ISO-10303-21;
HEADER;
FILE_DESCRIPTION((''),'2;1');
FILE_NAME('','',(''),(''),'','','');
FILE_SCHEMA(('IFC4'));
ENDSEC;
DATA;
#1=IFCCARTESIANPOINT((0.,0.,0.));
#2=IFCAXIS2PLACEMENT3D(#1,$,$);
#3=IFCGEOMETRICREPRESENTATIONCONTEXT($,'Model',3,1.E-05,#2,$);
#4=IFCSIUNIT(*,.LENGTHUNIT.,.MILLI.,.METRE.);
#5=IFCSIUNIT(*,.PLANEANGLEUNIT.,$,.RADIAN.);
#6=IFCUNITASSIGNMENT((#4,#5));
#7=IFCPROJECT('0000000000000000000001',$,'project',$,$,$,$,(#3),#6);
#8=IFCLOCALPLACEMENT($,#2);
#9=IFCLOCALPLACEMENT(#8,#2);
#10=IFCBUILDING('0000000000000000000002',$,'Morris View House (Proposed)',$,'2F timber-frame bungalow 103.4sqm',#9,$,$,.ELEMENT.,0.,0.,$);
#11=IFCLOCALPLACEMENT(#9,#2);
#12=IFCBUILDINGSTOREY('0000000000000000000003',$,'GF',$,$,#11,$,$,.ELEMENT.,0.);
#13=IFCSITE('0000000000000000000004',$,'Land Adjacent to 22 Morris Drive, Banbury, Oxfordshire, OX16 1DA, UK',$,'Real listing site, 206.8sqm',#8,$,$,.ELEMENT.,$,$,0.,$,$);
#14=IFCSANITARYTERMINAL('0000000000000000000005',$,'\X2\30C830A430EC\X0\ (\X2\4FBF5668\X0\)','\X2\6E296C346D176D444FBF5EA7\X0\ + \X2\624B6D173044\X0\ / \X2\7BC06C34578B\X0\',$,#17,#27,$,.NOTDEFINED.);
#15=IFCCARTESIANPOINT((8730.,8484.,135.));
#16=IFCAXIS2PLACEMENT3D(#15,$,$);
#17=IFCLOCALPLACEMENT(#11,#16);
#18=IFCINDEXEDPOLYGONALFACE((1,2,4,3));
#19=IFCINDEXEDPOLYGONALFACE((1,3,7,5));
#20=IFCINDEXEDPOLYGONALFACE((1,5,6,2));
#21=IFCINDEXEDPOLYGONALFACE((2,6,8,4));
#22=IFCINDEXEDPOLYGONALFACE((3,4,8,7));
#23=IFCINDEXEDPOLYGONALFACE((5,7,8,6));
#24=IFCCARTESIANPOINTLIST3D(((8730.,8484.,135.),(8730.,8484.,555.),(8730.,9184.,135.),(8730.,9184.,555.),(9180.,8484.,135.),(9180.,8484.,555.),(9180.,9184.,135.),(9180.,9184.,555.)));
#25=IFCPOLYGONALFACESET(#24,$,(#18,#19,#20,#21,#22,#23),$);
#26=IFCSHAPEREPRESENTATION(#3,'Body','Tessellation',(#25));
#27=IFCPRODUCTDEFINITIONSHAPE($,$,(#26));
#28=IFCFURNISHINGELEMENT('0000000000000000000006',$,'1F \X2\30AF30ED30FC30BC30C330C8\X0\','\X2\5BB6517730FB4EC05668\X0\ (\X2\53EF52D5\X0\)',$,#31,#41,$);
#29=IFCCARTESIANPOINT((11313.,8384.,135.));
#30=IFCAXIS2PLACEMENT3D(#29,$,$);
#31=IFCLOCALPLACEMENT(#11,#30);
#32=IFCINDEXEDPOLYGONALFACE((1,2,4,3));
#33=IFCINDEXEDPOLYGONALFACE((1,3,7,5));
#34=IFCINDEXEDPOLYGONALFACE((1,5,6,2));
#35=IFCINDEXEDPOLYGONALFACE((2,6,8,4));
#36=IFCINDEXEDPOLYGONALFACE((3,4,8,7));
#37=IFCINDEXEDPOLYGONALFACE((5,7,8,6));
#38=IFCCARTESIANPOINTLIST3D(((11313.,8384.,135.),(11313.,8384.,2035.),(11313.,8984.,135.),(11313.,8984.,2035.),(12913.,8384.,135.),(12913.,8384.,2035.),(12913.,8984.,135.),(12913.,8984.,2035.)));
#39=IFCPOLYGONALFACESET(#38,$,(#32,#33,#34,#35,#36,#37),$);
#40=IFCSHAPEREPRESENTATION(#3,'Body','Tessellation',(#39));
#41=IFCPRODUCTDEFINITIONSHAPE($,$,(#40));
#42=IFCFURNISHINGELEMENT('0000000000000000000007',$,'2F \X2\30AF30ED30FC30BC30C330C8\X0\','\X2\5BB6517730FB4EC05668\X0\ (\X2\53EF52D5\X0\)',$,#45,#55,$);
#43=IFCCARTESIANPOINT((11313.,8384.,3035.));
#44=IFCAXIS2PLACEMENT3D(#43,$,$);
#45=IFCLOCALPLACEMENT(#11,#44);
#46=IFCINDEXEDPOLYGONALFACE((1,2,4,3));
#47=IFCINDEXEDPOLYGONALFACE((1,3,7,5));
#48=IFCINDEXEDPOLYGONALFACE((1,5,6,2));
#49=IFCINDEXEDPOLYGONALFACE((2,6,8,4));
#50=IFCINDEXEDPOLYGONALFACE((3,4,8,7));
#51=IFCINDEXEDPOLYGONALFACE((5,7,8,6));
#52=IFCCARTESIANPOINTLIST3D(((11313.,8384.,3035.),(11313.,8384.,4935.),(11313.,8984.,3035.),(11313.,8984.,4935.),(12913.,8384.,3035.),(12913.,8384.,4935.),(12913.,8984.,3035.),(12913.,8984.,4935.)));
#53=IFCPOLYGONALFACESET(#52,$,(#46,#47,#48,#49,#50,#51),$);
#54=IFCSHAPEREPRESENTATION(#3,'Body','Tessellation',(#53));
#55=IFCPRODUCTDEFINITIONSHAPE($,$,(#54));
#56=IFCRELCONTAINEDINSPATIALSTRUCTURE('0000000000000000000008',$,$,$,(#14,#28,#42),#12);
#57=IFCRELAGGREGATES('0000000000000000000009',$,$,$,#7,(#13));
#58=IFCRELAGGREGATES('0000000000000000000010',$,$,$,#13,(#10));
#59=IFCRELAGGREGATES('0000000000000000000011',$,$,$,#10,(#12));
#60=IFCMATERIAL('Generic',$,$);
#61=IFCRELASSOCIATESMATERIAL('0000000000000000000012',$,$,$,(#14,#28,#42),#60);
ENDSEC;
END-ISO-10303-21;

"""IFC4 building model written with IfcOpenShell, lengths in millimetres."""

from ifc_helpers import new_model, si_unit, frame, frame_2d, origin, place, context, project, spatial, rectangle, extrude, material, element, save


model = new_model("IFC4")

# Units and contexts
model_context = context("Model", 3, precision=1e-05, world=origin())
ifc_project = project(units=[si_unit("LENGTHUNIT", "METRE", prefix="MILLI"), si_unit("PLANEANGLEUNIT", "RADIAN")], contexts=[model_context])

# Site, building, storey
site_placement = place(None, origin())
site = spatial("IfcSite", under=ifc_project, at=site_placement, Name="Land Adjacent to 22 Morris Drive, Banbury, Oxfordshire, OX16 1DA, UK", ObjectType="Real listing site, 206.8sqm", CompositionType="ELEMENT", RefElevation=0.0)
building_placement = place(site_placement, origin())
building = spatial("IfcBuilding", under=site, at=building_placement, Name="Morris View House (Proposed)", ObjectType="2F timber-frame bungalow 103.4sqm", CompositionType="ELEMENT", ElevationOfRefHeight=0.0, ElevationOfTerrain=0.0)
storey_placement = place(building_placement, origin())
storey = spatial("IfcBuildingStorey", under=building, at=storey_placement, Name="GF", CompositionType="ELEMENT", Elevation=0.0)

# Shared definitions
ifc_material_1 = material(Name="Generic")

# Sanitary terminal
sanitary_terminal_1_placement = place(storey_placement, frame((8730.0, 8484.0, 135.0)))
element("IfcSanitaryTerminal", 1, at=sanitary_terminal_1_placement, inside=storey, material=ifc_material_1, Name="トイレ (便器)", Description="温水洗浄便座 + 手洗い / 節水型", PredefinedType="NOTDEFINED", context=model_context, shape_type="SweptSolid", body=[
    extrude(rectangle(XDim=450.0, YDim=700.0, at=frame_2d((225.0, 350.0))), frame((8730.0, 8484.0, 135.0)), (0.0, 0.0, 1.0), 420.0),
])

# Furnishing elements
furnishing_1_placement = place(storey_placement, frame((11313.0, 8384.0, 135.0)))
element("IfcFurnishingElement", 2, at=furnishing_1_placement, inside=storey, material=ifc_material_1, Name="1F クローゼット", Description="家具・什器 (可動)", context=model_context, shape_type="SweptSolid", body=[
    extrude(rectangle(XDim=1600.0, YDim=600.0, at=frame_2d((800.0, 300.0))), frame((11313.0, 8384.0, 135.0)), (0.0, 0.0, 1.0), 1900.0),
])
furnishing_2_placement = place(storey_placement, frame((11313.0, 8384.0, 3035.0)))
element("IfcFurnishingElement", 3, at=furnishing_2_placement, inside=storey, material=ifc_material_1, Name="2F クローゼット", Description="家具・什器 (可動)", context=model_context, shape_type="SweptSolid", body=[
    extrude(rectangle(XDim=1600.0, YDim=600.0, at=frame_2d((800.0, 300.0))), frame((11313.0, 8384.0, 3035.0)), (0.0, 0.0, 1.0), 1900.0),
])

save(model, "model.ifc")
